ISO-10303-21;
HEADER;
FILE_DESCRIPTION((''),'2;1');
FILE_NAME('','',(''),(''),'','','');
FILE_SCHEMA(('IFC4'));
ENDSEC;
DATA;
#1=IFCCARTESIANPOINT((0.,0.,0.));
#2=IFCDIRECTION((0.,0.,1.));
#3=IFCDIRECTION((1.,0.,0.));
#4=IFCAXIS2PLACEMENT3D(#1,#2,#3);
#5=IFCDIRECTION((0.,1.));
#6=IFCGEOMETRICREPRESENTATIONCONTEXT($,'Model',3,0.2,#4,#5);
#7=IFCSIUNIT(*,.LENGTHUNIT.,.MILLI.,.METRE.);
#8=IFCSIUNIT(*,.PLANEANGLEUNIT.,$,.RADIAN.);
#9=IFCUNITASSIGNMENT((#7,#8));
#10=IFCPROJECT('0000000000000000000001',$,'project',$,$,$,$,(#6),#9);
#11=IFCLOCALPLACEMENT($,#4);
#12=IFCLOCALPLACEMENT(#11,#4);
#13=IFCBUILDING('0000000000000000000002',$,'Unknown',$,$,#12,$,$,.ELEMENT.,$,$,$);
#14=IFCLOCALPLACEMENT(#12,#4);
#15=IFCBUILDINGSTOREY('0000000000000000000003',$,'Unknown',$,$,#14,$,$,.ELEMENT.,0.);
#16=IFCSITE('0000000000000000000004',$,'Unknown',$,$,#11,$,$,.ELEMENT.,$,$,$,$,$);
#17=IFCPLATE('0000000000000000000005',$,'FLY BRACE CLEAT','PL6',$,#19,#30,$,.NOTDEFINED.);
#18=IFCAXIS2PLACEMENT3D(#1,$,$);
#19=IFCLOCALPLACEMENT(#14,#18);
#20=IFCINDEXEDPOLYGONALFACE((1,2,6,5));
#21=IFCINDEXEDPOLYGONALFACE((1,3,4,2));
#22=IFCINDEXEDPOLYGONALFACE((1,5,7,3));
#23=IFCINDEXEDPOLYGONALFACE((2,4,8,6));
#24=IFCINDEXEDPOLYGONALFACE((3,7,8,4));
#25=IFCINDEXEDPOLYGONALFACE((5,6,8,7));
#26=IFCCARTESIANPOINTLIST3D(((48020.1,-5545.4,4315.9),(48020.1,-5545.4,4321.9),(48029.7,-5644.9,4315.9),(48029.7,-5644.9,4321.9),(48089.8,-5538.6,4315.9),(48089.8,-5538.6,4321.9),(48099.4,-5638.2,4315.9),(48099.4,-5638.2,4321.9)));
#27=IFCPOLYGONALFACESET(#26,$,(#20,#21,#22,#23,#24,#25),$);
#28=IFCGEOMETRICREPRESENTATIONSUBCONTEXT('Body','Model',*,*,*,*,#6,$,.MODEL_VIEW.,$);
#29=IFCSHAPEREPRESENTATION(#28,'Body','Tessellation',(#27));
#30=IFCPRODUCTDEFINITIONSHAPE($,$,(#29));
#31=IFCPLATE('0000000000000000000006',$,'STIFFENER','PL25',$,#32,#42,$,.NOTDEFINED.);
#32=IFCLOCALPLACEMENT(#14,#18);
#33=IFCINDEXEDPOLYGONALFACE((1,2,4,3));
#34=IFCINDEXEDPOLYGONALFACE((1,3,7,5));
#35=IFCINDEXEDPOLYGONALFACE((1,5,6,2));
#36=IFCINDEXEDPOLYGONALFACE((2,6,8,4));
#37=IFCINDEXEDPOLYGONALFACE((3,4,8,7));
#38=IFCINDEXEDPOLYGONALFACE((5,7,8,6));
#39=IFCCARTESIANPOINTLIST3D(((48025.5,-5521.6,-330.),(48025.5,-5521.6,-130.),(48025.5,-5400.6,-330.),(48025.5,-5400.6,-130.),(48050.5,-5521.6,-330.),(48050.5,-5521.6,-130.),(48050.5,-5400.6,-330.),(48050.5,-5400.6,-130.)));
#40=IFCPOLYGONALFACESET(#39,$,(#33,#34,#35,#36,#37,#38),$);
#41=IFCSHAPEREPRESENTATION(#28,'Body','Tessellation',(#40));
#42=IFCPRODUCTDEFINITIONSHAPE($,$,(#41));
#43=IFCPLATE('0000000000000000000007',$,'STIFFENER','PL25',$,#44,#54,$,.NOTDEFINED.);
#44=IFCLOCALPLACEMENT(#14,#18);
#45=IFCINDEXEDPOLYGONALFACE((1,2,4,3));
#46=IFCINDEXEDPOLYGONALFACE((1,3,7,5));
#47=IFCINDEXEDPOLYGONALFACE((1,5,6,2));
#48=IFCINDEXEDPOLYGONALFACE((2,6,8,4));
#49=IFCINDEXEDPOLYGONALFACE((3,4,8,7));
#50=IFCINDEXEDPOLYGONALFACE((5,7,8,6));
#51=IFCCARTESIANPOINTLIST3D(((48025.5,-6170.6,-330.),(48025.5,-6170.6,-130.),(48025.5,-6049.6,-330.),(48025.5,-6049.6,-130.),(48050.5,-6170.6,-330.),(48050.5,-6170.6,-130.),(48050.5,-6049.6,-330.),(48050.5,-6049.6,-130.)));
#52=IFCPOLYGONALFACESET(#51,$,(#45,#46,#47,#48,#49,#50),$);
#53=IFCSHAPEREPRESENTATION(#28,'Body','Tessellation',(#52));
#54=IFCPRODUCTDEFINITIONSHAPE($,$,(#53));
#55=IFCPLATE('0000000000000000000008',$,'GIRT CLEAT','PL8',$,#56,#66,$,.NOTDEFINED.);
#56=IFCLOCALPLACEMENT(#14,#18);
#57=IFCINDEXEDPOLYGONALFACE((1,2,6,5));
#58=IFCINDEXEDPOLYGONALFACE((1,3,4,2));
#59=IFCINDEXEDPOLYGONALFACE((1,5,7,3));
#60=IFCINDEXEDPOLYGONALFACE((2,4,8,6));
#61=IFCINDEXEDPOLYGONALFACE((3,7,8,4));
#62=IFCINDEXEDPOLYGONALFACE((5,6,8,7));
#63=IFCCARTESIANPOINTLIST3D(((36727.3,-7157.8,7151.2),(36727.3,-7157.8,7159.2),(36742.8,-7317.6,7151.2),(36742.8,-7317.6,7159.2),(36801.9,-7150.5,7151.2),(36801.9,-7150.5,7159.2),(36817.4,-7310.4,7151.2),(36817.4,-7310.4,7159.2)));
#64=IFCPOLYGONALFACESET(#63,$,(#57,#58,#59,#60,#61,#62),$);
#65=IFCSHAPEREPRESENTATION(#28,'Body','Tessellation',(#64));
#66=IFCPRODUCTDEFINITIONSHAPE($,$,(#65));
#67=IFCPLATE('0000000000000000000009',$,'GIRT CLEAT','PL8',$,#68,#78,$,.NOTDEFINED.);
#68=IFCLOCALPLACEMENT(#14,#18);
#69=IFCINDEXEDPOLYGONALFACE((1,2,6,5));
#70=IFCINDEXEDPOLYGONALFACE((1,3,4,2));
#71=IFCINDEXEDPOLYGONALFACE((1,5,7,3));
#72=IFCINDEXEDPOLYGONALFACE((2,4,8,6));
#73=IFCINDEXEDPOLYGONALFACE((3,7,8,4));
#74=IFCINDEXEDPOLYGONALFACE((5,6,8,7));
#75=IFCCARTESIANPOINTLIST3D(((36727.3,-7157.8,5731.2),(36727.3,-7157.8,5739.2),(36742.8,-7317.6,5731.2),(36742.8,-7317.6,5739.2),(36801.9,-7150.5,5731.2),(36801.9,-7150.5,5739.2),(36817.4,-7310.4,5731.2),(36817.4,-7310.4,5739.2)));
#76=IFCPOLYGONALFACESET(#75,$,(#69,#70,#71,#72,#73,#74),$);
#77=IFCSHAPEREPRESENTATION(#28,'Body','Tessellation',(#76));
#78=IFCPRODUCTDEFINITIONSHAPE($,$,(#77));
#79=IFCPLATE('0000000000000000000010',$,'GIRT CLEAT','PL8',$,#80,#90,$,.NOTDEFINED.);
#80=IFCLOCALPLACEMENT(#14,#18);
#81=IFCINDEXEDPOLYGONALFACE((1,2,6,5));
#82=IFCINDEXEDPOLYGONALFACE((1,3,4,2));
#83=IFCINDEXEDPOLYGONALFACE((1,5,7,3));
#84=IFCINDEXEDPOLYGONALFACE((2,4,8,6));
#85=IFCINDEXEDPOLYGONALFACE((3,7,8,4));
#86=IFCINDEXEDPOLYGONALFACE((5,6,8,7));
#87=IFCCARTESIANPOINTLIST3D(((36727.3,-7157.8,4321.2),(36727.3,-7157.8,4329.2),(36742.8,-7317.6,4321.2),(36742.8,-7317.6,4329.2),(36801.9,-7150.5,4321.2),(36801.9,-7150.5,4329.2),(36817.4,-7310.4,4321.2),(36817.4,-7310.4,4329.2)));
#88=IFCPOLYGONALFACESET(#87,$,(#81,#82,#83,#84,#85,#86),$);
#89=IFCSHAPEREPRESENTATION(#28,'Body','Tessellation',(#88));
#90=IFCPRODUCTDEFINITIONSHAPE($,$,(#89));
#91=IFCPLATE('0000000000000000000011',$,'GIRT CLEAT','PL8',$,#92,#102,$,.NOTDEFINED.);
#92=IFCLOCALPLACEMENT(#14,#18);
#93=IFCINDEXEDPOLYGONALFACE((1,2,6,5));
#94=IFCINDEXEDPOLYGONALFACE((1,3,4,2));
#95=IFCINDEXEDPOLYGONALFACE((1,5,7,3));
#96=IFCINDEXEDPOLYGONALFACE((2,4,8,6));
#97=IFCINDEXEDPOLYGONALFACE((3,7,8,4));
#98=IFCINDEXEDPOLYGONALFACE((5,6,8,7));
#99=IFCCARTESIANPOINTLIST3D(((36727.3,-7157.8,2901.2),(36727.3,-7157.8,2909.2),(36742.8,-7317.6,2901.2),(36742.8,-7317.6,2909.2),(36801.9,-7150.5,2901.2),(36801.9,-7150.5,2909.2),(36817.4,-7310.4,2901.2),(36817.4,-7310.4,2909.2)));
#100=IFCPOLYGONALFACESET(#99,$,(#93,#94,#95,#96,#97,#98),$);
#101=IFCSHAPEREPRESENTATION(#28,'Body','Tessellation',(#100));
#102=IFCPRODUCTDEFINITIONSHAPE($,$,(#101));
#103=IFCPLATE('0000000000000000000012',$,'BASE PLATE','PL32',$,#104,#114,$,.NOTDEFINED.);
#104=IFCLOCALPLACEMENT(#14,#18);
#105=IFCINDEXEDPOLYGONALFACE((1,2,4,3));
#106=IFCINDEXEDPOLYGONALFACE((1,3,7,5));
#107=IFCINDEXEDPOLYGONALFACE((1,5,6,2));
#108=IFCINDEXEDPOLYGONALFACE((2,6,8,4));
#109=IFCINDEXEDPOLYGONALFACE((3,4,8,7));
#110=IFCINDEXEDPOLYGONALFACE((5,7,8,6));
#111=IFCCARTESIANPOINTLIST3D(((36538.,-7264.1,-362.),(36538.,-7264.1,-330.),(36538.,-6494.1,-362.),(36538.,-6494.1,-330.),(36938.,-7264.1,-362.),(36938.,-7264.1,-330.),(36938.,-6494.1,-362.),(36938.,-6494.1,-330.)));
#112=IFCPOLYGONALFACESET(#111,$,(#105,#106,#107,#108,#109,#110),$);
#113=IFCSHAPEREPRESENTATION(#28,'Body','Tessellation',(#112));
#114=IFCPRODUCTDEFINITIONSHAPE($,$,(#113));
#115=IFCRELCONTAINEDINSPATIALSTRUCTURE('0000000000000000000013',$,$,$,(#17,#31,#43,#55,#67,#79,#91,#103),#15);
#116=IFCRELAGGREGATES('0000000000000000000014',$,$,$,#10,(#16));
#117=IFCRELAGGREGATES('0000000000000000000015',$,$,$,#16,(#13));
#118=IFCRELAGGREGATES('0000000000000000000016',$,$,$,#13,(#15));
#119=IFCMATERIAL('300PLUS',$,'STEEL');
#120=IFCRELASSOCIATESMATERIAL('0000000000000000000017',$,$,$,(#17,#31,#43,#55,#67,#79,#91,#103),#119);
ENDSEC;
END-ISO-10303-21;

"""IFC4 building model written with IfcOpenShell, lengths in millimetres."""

from ifc_helpers import new_model, si_unit, direction, frame, origin_with_axes, place, context, subcontext, project, spatial, line, indexed_curve, outline, extrude, material, element, save


model = new_model("IFC4")

# Units and contexts
model_context = context("Model", 3, precision=0.2, world=origin_with_axes(), true_north=direction((0.0, 1.0)))
body_context = subcontext(model_context, "Body", "Model", "MODEL_VIEW")
ifc_project = project(units=[si_unit("LENGTHUNIT", "METRE", prefix="MILLI"), si_unit("PLANEANGLEUNIT", "RADIAN")], contexts=[model_context])

# Site, building, storey
site_placement = place(None, origin_with_axes())
site = spatial("IfcSite", under=ifc_project, at=site_placement, Name="Unknown", CompositionType="ELEMENT")
building_placement = place(site_placement, origin_with_axes())
building = spatial("IfcBuilding", under=site, at=building_placement, Name="Unknown", CompositionType="ELEMENT")
storey_placement = place(building_placement, origin_with_axes())
storey = spatial("IfcBuildingStorey", under=building, at=storey_placement, Name="Unknown", CompositionType="ELEMENT", Elevation=0.0)

# Shared definitions
ifc_material_1 = material(Name="300PLUS", Category="STEEL")

# Plates
plate_1_placement = place(storey_placement, frame((48029.7, -5644.9, 4318.9), z_axis=(0.0, 0.0, 1.0), x_axis=(0.995412, 0.095685, 0.0)))
element("IfcPlate", 1, at=plate_1_placement, inside=storey, material=ifc_material_1, Name="FLY BRACE CLEAT", Description="PL6", PredefinedType="NOTDEFINED", context=body_context, shape_type="SolidModel", body=[
    extrude(outline(indexed_curve([(0.0, 0.0), (70.0, 0.0), (70.0, 100.1), (0.0, 100.0)], segments=[line(1, 2, 3, 4, 1)])), frame((0.0, 0.0, 3.0), z_axis=(0.0, 0.0, 1.0), x_axis=(1.0, 0.0, 0.0)), (0.0, 0.0, -1.0), 6.0),
])
for number, where, z_axis, x_axis, name in (
    (2, (48038.0, -5521.6, -330.0), (1.0, 0.0, 0.0), (0.0, 1.0, 0.0), "STIFFENER"),
    (3, (48038.0, -6049.6, -130.0), (1.0, 0.0, 0.0), (0.0, -1.0, 0.0), "STIFFENER"),
):
    element("IfcPlate", number, at=place(storey_placement, frame(where, z_axis=z_axis, x_axis=x_axis)), inside=storey, material=ifc_material_1, Name=name, Description="PL25", PredefinedType="NOTDEFINED", context=body_context, shape_type="SolidModel", body=[
        extrude(outline(indexed_curve([(0.0, 0.0), (121.0, 0.0), (121.0, 200.0), (0.0, 200.0)], segments=[line(1, 2, 3, 4, 1)])), frame((0.0, 0.0, 12.5), z_axis=(0.0, 0.0, 1.0), x_axis=(1.0, 0.0, 0.0)), (0.0, 0.0, -1.0), 25.0),
    ])
for number, where, z_axis, x_axis, name in (
    (4, (36742.8, -7317.6, 7155.2), (0.0, 0.0, 1.0), (0.995375, 0.096068, 0.0), "GIRT CLEAT"),
    (5, (36742.8, -7317.6, 5735.2), (0.0, 0.0, 1.0), (0.995375, 0.096068, 0.0), "GIRT CLEAT"),
    (6, (36742.8, -7317.6, 4325.2), (0.0, 0.0, 1.0), (0.995375, 0.096068, 0.0), "GIRT CLEAT"),
    (7, (36742.8, -7317.6, 2905.2), (0.0, 0.0, 1.0), (0.995375, 0.096068, 0.0), "GIRT CLEAT"),
):
    element("IfcPlate", number, at=place(storey_placement, frame(where, z_axis=z_axis, x_axis=x_axis)), inside=storey, material=ifc_material_1, Name=name, Description="PL8", PredefinedType="NOTDEFINED", context=body_context, shape_type="SolidModel", body=[
        extrude(outline(indexed_curve([(0.0, 0.0), (74.9, 0.0), (74.9, 160.6), (-0.1, 160.5)], segments=[line(1, 2, 3, 4, 1)])), frame((0.0, 0.0, 4.0), z_axis=(0.0, 0.0, 1.0), x_axis=(1.0, 0.0, 0.0)), (0.0, 0.0, -1.0), 8.0),
    ])
plate_2_placement = place(storey_placement, frame((36938.0, -7264.1, -346.0), z_axis=(0.0, 0.0, 1.0), x_axis=(0.0, 1.0, 0.0)))
element("IfcPlate", 8, at=plate_2_placement, inside=storey, material=ifc_material_1, Name="BASE PLATE", Description="PL32", PredefinedType="NOTDEFINED", context=body_context, shape_type="SolidModel", body=[
    extrude(outline(indexed_curve([(0.0, 0.0), (770.0, 0.0), (770.0, 400.0), (0.0, 400.0)], segments=[line(1, 2, 3, 4, 1)])), frame((0.0, 0.0, 16.0), z_axis=(0.0, 0.0, 1.0), x_axis=(1.0, 0.0, 0.0)), (0.0, 0.0, -1.0), 32.0),
])

save(model, "model.ifc")
